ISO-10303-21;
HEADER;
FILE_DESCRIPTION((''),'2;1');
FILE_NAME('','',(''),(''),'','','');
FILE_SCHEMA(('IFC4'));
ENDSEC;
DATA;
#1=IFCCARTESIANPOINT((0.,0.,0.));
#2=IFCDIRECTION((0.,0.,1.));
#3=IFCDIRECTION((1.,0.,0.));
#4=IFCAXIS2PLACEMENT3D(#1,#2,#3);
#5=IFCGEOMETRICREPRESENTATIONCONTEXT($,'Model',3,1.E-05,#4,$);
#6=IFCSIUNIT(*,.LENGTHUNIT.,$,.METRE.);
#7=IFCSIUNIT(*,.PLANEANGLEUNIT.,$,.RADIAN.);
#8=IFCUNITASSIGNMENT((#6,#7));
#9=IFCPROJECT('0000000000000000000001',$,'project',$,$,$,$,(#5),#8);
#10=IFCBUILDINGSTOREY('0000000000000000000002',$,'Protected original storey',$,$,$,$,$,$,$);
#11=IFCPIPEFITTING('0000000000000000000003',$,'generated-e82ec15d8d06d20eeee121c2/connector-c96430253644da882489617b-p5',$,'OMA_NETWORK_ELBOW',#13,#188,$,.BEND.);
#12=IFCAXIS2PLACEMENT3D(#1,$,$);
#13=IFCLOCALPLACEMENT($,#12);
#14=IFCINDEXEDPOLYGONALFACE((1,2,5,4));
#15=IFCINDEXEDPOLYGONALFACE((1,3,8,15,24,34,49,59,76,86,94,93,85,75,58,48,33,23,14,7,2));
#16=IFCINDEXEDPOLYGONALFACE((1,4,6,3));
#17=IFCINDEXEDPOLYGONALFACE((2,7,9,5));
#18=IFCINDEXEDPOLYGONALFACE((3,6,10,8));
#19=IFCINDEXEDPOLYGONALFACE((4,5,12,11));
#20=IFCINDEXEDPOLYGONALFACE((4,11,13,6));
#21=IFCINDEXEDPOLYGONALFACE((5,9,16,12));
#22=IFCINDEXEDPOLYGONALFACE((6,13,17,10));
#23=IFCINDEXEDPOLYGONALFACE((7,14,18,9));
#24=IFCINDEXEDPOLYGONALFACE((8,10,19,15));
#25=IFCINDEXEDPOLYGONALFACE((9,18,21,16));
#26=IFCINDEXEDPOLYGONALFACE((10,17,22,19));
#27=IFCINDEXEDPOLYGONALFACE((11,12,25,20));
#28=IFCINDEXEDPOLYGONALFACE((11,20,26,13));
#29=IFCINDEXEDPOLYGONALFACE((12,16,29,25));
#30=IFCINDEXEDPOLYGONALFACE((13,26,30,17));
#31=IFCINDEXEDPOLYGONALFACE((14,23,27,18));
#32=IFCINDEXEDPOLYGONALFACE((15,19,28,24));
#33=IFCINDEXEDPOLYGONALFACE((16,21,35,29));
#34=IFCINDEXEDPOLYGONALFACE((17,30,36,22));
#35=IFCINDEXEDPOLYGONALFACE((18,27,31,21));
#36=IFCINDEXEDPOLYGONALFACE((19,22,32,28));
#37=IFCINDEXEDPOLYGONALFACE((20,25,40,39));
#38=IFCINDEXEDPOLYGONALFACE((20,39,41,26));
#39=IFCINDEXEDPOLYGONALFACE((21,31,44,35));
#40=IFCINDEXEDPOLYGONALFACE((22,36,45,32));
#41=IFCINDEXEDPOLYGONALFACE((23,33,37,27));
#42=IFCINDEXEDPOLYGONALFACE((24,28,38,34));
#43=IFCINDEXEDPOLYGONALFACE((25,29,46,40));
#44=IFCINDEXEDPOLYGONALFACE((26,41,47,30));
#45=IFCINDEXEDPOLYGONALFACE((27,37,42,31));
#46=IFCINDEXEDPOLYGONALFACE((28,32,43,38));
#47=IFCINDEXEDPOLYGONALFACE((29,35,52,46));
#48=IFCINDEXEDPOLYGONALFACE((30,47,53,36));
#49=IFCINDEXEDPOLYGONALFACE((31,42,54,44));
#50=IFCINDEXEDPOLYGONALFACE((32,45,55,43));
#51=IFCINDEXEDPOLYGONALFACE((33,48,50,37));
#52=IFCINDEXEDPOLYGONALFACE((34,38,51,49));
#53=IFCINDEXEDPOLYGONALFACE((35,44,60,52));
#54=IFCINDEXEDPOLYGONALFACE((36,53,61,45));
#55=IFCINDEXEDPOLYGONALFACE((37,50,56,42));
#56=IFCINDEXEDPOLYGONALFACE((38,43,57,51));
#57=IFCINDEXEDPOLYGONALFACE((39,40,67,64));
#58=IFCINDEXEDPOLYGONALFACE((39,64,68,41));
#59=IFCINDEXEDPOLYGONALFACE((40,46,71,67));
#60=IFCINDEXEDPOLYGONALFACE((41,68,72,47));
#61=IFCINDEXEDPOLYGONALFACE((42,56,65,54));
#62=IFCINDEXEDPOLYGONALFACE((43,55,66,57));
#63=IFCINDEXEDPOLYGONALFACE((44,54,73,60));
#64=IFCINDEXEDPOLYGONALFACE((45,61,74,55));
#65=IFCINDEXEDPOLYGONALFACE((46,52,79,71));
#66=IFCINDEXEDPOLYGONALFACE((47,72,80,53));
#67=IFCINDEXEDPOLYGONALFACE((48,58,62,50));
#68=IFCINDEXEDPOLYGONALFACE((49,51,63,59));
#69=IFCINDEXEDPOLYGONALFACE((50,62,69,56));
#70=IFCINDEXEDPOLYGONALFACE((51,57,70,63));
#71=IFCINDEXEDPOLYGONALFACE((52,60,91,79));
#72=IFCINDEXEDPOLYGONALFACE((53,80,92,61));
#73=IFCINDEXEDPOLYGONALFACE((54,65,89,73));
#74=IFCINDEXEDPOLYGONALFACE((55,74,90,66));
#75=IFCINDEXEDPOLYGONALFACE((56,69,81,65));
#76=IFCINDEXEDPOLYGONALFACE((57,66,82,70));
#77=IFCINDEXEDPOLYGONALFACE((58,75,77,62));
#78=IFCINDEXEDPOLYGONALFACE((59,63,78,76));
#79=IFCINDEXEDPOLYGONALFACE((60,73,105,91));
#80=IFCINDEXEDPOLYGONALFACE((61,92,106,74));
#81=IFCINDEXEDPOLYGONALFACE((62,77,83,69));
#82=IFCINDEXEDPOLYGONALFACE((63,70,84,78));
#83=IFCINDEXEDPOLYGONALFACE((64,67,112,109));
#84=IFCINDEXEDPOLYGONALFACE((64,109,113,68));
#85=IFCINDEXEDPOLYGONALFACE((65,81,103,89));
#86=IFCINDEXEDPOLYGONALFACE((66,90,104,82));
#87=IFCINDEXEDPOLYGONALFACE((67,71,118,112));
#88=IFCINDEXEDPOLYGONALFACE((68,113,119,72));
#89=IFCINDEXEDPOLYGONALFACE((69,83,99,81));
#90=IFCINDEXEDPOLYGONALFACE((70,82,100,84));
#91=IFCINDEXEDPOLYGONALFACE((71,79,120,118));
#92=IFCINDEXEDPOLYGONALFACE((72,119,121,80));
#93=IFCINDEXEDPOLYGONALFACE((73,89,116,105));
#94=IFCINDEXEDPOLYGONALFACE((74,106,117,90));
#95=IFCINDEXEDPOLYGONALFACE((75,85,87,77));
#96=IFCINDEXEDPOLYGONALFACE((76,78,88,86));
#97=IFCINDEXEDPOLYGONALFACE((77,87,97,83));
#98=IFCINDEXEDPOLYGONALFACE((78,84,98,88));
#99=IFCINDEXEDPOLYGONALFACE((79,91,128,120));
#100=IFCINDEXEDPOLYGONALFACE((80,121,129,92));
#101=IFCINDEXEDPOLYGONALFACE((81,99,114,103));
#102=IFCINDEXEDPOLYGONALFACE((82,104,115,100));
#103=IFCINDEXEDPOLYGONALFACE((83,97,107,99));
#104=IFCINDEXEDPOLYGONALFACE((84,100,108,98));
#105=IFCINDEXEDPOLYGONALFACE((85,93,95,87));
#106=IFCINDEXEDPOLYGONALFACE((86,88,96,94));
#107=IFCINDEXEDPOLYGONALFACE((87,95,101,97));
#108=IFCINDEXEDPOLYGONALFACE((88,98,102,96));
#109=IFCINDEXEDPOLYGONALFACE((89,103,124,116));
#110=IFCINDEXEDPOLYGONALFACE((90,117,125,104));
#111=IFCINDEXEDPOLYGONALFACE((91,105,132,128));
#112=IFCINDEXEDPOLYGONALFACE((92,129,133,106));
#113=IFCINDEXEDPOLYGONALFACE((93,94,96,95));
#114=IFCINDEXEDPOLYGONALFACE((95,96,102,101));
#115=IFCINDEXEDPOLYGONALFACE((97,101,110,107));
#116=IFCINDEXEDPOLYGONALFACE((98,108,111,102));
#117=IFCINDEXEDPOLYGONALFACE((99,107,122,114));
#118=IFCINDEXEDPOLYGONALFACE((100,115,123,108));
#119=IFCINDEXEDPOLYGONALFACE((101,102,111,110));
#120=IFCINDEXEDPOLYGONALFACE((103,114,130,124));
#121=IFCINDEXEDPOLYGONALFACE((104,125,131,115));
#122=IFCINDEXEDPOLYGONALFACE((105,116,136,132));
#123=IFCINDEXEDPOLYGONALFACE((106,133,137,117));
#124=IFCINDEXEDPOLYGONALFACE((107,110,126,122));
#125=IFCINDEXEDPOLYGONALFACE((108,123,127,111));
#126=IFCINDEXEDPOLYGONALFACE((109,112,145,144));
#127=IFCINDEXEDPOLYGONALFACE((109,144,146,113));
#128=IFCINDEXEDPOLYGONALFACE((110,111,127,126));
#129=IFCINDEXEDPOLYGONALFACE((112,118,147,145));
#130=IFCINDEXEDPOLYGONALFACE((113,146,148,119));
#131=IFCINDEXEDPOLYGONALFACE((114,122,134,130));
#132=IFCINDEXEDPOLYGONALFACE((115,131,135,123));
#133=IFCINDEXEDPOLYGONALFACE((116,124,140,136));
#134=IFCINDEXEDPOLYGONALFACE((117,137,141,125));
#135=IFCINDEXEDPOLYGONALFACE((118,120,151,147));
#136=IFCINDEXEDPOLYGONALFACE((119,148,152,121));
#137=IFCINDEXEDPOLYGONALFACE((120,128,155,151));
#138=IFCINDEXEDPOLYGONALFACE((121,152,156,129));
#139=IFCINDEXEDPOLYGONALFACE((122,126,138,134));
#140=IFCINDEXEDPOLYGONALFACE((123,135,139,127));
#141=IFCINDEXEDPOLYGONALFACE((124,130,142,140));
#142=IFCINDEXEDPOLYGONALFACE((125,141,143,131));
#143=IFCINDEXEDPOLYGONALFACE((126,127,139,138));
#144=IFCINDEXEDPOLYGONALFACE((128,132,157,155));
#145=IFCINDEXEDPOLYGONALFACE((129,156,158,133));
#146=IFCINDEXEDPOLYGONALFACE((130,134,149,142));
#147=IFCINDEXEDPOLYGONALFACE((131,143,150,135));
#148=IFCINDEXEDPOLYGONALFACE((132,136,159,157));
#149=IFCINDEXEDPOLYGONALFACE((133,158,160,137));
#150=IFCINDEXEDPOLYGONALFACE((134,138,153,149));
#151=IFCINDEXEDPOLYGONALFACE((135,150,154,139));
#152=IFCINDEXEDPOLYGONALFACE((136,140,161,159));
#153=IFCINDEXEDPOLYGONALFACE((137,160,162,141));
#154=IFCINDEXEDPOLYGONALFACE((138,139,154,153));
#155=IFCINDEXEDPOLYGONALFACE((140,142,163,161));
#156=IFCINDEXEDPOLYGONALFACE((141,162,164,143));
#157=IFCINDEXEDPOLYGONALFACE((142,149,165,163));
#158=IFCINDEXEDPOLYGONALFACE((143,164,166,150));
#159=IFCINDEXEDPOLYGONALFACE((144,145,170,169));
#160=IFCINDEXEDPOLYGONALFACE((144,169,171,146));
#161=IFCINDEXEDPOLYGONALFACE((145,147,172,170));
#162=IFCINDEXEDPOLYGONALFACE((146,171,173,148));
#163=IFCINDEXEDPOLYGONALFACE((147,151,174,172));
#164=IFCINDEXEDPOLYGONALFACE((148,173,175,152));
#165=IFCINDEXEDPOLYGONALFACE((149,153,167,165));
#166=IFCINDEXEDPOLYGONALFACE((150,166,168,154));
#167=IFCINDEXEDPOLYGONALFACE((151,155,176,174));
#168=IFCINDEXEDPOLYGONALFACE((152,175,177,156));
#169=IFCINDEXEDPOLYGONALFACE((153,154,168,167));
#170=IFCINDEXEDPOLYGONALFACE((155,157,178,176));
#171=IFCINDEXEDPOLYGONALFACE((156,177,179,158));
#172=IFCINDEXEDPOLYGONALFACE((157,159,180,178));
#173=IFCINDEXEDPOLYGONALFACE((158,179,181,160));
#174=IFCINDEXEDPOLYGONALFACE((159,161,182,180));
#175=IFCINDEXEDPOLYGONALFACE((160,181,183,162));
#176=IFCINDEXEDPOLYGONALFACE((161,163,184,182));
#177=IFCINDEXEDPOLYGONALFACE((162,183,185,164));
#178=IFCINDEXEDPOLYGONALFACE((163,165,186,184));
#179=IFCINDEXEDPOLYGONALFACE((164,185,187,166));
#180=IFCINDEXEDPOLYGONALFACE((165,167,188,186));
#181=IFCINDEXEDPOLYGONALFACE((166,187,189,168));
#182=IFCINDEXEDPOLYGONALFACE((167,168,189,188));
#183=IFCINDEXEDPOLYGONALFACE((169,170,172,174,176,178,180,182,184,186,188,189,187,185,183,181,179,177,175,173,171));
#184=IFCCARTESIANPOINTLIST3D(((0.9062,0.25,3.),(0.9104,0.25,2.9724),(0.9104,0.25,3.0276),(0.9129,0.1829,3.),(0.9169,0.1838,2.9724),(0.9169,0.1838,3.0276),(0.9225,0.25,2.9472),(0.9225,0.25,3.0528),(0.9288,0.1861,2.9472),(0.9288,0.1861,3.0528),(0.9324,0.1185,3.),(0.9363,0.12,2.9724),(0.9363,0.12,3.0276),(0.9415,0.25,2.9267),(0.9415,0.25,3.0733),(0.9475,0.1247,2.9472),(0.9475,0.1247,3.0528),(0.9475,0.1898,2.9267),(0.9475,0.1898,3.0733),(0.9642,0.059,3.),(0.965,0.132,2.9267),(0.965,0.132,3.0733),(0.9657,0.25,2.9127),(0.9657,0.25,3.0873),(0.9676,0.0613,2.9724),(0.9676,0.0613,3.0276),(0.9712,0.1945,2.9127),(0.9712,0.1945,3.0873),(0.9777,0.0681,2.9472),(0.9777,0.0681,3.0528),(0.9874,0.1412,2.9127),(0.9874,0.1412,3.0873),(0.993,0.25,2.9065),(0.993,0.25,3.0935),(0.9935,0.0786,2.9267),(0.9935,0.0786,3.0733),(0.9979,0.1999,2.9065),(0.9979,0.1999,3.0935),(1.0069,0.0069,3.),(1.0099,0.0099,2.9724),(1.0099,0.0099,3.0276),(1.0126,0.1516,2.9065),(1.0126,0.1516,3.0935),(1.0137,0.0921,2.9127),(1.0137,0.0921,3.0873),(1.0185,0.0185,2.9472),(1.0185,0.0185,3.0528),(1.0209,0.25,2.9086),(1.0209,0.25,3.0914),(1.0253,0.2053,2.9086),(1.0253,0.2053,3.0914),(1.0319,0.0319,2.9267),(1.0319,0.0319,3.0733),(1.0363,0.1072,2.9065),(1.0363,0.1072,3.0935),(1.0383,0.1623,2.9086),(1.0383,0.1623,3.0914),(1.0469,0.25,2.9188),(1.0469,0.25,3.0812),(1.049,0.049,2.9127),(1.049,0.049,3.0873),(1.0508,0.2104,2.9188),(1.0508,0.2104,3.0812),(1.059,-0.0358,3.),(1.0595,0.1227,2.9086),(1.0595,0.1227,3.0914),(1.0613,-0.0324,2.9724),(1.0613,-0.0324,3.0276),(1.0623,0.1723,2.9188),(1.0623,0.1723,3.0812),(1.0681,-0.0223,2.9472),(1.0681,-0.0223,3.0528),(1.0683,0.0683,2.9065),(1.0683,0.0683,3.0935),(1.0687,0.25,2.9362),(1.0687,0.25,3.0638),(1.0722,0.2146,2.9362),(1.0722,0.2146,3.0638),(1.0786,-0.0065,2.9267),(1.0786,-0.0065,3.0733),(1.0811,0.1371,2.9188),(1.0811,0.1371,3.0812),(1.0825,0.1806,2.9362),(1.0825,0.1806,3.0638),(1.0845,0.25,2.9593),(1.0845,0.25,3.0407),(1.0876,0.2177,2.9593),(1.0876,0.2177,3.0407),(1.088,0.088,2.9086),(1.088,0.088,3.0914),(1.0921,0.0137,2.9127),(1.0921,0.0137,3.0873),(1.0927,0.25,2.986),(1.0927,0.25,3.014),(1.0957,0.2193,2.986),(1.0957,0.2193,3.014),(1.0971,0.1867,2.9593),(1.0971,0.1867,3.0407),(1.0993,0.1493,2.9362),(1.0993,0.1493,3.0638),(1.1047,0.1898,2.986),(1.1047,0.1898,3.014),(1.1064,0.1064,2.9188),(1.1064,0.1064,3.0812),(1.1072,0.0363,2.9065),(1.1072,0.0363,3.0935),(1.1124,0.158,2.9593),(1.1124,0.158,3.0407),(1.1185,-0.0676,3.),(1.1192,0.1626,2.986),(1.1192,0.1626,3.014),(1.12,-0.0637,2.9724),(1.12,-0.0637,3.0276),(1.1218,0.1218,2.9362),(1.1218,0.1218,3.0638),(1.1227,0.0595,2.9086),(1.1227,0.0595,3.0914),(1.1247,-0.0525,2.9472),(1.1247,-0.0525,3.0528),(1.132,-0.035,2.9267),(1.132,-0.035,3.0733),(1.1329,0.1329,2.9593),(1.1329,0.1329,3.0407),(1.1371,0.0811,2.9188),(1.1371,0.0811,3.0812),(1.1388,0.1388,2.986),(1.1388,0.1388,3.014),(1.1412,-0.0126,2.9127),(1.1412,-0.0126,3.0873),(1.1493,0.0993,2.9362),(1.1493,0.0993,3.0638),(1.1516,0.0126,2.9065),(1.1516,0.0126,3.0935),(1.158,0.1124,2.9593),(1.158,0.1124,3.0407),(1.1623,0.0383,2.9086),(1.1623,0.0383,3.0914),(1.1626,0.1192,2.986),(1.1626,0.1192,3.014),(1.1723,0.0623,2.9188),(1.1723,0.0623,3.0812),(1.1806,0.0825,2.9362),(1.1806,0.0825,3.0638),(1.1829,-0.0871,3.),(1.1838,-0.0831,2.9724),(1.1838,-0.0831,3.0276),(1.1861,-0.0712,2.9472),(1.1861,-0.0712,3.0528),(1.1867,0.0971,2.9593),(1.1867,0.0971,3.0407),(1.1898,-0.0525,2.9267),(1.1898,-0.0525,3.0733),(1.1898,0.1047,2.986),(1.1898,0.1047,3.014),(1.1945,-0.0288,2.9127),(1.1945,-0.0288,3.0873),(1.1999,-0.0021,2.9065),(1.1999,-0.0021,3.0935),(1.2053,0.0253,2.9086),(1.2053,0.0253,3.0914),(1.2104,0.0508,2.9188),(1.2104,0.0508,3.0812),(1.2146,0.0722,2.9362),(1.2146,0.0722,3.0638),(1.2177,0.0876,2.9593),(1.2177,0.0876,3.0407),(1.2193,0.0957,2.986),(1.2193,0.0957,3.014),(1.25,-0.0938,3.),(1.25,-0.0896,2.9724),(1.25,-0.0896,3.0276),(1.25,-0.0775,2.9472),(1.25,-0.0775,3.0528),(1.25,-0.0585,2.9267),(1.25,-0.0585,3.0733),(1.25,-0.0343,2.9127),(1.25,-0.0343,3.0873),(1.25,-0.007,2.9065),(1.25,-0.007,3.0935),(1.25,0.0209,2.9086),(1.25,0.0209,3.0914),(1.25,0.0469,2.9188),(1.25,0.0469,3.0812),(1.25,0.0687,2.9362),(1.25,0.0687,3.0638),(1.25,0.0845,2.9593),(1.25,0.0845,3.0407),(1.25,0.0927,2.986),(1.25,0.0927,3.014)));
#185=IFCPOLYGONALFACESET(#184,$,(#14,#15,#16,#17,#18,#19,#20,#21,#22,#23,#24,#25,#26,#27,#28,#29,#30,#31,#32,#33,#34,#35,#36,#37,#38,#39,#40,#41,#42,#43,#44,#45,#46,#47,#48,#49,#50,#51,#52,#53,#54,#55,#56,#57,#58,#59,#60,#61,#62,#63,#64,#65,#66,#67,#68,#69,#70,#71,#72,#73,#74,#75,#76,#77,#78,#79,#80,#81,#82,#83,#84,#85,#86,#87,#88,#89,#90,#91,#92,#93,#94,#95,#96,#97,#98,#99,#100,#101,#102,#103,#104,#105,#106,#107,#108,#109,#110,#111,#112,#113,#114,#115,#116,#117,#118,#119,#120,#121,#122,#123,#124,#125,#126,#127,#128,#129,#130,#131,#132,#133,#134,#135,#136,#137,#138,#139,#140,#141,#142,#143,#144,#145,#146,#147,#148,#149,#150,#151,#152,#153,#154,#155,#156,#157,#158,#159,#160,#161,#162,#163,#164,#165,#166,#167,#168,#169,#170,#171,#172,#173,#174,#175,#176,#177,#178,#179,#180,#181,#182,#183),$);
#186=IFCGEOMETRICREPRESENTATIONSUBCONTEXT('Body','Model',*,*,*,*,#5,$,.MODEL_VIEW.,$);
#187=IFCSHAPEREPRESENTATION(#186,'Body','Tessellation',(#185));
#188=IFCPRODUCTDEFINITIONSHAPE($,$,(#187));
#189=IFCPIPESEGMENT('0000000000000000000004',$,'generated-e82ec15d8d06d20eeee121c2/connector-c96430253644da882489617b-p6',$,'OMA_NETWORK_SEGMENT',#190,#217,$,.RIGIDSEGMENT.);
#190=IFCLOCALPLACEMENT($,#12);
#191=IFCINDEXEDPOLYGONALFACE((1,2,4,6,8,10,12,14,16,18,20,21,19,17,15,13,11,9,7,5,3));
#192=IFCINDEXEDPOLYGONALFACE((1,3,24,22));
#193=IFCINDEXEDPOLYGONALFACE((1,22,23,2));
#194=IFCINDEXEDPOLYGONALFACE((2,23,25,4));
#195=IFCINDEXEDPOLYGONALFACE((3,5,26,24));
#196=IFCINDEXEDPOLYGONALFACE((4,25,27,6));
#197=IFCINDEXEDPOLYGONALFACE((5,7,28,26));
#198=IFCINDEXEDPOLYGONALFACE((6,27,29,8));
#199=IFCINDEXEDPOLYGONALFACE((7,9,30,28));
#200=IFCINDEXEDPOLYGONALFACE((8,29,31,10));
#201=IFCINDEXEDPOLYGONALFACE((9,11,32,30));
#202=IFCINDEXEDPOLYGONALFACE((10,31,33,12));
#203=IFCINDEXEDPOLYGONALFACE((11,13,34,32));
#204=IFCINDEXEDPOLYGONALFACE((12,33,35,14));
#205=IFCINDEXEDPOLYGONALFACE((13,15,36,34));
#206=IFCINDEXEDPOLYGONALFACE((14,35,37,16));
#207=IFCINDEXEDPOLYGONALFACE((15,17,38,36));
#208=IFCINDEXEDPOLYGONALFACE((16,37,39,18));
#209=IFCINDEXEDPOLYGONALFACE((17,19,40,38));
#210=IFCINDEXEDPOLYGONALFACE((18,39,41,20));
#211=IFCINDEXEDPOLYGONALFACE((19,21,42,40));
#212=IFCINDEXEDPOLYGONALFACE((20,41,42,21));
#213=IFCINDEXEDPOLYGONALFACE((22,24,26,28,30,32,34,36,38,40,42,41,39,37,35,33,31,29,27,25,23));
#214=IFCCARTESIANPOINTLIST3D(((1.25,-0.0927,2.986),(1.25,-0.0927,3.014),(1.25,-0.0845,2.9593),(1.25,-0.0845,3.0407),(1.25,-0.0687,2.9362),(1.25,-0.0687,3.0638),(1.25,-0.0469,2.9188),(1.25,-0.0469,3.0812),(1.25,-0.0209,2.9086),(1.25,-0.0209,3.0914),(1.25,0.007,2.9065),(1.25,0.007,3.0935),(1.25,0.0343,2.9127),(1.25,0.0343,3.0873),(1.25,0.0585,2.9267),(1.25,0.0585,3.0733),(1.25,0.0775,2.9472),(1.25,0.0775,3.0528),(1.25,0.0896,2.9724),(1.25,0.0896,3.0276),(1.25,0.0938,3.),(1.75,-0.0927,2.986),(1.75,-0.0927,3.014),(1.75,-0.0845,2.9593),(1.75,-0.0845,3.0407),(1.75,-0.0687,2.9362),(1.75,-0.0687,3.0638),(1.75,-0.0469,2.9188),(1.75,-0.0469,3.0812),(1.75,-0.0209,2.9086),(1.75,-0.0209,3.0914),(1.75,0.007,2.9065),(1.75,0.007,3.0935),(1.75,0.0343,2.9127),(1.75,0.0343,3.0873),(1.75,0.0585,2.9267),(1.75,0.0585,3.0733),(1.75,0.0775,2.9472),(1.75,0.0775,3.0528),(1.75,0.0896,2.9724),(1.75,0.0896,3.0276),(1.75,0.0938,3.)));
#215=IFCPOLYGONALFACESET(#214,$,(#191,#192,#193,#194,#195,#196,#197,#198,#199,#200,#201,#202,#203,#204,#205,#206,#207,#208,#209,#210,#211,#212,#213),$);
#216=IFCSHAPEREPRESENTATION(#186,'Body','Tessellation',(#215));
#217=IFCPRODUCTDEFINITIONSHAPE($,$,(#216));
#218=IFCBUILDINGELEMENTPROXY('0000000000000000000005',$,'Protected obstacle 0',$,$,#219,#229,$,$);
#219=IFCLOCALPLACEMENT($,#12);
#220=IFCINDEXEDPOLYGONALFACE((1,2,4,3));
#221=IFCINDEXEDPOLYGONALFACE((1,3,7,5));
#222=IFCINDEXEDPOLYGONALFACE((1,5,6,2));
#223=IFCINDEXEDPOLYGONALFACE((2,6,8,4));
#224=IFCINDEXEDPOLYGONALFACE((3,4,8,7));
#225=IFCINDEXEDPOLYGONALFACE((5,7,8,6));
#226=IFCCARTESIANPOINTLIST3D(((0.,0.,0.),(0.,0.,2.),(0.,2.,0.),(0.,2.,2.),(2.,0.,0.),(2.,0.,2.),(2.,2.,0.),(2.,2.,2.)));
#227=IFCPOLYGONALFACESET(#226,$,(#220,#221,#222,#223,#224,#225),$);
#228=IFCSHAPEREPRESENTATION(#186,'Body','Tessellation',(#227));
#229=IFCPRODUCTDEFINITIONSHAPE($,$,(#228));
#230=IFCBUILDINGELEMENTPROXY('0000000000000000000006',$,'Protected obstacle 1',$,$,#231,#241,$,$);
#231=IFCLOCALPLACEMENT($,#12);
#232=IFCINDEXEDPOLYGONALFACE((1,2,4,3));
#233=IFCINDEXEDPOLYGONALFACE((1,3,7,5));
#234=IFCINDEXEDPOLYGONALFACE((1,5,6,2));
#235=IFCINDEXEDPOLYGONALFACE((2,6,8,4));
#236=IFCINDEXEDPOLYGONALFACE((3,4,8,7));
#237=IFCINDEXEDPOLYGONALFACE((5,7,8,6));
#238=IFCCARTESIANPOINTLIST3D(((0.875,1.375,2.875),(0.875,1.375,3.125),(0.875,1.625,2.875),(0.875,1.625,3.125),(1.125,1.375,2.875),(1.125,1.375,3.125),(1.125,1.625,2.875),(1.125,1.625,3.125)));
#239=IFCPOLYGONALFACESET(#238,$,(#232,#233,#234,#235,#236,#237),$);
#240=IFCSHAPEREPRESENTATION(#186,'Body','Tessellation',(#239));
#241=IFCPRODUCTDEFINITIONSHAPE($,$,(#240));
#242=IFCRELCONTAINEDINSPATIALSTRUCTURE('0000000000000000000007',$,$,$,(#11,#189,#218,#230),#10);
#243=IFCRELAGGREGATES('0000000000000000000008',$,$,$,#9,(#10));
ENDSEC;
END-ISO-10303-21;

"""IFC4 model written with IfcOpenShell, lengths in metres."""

from ifc_helpers import new_model, entity, si_unit, frame, origin_with_axes, origin_2d, place, context, subcontext, project, spatial, indexed_curve, circle, outline, extrude, element, save


model = new_model("IFC4")

# Units and contexts
model_context = context("Model", 3, precision=1e-05, world=origin_with_axes())
body_context = subcontext(model_context, "Body", "Model", "MODEL_VIEW")
ifc_project = project(units=[si_unit("LENGTHUNIT", "METRE"), si_unit("PLANEANGLEUNIT", "RADIAN")], contexts=[model_context])

# Storey
storey = spatial("IfcBuildingStorey", under=ifc_project, Name="Protected original storey")

# Pipe fitting
pipe_fitting_1_placement = place(None, origin_with_axes())
element("IfcPipeFitting", 1, at=pipe_fitting_1_placement, inside=storey, Name="generated-e82ec15d8d06d20eeee121c2/connector-c96430253644da882489617b-p5", ObjectType="OMA_NETWORK_ELBOW", PredefinedType="BEND", context=body_context, shape_type="SweptSolid", body=[
    entity("IfcRevolvedAreaSolid", entity("IfcCircleProfileDef", "AREA", None, entity("IfcAxis2Placement2D", entity("IfcCartesianPoint", [0.25, 0.0])), 0.0938), entity("IfcAxis2Placement3D", entity("IfcCartesianPoint", [1.25, 0.25, 3.0]), entity("IfcDirection", [0.0, -1.0, 0.0]), entity("IfcDirection", [-1.0, 0.0, 0.0])), entity("IfcAxis1Placement", entity("IfcCartesianPoint", [0.0, 0.0, 0.0]), entity("IfcDirection", [0.0, -1.0, 0.0])), 1.570796),
])

# Pipe segment
pipe_segment_1_placement = place(None, origin_with_axes())
element("IfcPipeSegment", 2, at=pipe_segment_1_placement, inside=storey, Name="generated-e82ec15d8d06d20eeee121c2/connector-c96430253644da882489617b-p6", ObjectType="OMA_NETWORK_SEGMENT", PredefinedType="RIGIDSEGMENT", context=body_context, shape_type="SweptSolid", body=[
    extrude(circle(Radius=0.0938, at=origin_2d()), frame((1.25, 0.0, 3.0), z_axis=(1.0, 0.0, 0.0), x_axis=(0.0, 1.0, 0.0)), (0.0, 0.0, 1.0), 0.5),
])

# Building element proxies
proxy_1_placement = place(None, origin_with_axes())
element("IfcBuildingElementProxy", 3, at=proxy_1_placement, inside=storey, Name="Protected obstacle 0", context=body_context, shape_type="SweptSolid", body=[
    extrude(outline(indexed_curve([(0.0, 0.0), (0.0, 2.0), (2.0, 2.0), (2.0, 0.0), (0.0, 0.0)], self_intersect=False)), origin_with_axes(), (0.0, 0.0, 1.0), 2.0),
])
proxy_2_placement = place(None, frame((0.875, 1.375, 2.875), z_axis=(0.0, 0.0, 1.0), x_axis=(1.0, 0.0, 0.0)))
element("IfcBuildingElementProxy", 4, at=proxy_2_placement, inside=storey, Name="Protected obstacle 1", context=body_context, shape_type="SweptSolid", body=[
    extrude(outline(indexed_curve([(0.0, 0.0), (0.0, 0.25), (0.25, 0.25), (0.25, 0.0), (0.0, 0.0)], self_intersect=False)), origin_with_axes(), (0.0, 0.0, 1.0), 0.25),
])

save(model, "model.ifc")
